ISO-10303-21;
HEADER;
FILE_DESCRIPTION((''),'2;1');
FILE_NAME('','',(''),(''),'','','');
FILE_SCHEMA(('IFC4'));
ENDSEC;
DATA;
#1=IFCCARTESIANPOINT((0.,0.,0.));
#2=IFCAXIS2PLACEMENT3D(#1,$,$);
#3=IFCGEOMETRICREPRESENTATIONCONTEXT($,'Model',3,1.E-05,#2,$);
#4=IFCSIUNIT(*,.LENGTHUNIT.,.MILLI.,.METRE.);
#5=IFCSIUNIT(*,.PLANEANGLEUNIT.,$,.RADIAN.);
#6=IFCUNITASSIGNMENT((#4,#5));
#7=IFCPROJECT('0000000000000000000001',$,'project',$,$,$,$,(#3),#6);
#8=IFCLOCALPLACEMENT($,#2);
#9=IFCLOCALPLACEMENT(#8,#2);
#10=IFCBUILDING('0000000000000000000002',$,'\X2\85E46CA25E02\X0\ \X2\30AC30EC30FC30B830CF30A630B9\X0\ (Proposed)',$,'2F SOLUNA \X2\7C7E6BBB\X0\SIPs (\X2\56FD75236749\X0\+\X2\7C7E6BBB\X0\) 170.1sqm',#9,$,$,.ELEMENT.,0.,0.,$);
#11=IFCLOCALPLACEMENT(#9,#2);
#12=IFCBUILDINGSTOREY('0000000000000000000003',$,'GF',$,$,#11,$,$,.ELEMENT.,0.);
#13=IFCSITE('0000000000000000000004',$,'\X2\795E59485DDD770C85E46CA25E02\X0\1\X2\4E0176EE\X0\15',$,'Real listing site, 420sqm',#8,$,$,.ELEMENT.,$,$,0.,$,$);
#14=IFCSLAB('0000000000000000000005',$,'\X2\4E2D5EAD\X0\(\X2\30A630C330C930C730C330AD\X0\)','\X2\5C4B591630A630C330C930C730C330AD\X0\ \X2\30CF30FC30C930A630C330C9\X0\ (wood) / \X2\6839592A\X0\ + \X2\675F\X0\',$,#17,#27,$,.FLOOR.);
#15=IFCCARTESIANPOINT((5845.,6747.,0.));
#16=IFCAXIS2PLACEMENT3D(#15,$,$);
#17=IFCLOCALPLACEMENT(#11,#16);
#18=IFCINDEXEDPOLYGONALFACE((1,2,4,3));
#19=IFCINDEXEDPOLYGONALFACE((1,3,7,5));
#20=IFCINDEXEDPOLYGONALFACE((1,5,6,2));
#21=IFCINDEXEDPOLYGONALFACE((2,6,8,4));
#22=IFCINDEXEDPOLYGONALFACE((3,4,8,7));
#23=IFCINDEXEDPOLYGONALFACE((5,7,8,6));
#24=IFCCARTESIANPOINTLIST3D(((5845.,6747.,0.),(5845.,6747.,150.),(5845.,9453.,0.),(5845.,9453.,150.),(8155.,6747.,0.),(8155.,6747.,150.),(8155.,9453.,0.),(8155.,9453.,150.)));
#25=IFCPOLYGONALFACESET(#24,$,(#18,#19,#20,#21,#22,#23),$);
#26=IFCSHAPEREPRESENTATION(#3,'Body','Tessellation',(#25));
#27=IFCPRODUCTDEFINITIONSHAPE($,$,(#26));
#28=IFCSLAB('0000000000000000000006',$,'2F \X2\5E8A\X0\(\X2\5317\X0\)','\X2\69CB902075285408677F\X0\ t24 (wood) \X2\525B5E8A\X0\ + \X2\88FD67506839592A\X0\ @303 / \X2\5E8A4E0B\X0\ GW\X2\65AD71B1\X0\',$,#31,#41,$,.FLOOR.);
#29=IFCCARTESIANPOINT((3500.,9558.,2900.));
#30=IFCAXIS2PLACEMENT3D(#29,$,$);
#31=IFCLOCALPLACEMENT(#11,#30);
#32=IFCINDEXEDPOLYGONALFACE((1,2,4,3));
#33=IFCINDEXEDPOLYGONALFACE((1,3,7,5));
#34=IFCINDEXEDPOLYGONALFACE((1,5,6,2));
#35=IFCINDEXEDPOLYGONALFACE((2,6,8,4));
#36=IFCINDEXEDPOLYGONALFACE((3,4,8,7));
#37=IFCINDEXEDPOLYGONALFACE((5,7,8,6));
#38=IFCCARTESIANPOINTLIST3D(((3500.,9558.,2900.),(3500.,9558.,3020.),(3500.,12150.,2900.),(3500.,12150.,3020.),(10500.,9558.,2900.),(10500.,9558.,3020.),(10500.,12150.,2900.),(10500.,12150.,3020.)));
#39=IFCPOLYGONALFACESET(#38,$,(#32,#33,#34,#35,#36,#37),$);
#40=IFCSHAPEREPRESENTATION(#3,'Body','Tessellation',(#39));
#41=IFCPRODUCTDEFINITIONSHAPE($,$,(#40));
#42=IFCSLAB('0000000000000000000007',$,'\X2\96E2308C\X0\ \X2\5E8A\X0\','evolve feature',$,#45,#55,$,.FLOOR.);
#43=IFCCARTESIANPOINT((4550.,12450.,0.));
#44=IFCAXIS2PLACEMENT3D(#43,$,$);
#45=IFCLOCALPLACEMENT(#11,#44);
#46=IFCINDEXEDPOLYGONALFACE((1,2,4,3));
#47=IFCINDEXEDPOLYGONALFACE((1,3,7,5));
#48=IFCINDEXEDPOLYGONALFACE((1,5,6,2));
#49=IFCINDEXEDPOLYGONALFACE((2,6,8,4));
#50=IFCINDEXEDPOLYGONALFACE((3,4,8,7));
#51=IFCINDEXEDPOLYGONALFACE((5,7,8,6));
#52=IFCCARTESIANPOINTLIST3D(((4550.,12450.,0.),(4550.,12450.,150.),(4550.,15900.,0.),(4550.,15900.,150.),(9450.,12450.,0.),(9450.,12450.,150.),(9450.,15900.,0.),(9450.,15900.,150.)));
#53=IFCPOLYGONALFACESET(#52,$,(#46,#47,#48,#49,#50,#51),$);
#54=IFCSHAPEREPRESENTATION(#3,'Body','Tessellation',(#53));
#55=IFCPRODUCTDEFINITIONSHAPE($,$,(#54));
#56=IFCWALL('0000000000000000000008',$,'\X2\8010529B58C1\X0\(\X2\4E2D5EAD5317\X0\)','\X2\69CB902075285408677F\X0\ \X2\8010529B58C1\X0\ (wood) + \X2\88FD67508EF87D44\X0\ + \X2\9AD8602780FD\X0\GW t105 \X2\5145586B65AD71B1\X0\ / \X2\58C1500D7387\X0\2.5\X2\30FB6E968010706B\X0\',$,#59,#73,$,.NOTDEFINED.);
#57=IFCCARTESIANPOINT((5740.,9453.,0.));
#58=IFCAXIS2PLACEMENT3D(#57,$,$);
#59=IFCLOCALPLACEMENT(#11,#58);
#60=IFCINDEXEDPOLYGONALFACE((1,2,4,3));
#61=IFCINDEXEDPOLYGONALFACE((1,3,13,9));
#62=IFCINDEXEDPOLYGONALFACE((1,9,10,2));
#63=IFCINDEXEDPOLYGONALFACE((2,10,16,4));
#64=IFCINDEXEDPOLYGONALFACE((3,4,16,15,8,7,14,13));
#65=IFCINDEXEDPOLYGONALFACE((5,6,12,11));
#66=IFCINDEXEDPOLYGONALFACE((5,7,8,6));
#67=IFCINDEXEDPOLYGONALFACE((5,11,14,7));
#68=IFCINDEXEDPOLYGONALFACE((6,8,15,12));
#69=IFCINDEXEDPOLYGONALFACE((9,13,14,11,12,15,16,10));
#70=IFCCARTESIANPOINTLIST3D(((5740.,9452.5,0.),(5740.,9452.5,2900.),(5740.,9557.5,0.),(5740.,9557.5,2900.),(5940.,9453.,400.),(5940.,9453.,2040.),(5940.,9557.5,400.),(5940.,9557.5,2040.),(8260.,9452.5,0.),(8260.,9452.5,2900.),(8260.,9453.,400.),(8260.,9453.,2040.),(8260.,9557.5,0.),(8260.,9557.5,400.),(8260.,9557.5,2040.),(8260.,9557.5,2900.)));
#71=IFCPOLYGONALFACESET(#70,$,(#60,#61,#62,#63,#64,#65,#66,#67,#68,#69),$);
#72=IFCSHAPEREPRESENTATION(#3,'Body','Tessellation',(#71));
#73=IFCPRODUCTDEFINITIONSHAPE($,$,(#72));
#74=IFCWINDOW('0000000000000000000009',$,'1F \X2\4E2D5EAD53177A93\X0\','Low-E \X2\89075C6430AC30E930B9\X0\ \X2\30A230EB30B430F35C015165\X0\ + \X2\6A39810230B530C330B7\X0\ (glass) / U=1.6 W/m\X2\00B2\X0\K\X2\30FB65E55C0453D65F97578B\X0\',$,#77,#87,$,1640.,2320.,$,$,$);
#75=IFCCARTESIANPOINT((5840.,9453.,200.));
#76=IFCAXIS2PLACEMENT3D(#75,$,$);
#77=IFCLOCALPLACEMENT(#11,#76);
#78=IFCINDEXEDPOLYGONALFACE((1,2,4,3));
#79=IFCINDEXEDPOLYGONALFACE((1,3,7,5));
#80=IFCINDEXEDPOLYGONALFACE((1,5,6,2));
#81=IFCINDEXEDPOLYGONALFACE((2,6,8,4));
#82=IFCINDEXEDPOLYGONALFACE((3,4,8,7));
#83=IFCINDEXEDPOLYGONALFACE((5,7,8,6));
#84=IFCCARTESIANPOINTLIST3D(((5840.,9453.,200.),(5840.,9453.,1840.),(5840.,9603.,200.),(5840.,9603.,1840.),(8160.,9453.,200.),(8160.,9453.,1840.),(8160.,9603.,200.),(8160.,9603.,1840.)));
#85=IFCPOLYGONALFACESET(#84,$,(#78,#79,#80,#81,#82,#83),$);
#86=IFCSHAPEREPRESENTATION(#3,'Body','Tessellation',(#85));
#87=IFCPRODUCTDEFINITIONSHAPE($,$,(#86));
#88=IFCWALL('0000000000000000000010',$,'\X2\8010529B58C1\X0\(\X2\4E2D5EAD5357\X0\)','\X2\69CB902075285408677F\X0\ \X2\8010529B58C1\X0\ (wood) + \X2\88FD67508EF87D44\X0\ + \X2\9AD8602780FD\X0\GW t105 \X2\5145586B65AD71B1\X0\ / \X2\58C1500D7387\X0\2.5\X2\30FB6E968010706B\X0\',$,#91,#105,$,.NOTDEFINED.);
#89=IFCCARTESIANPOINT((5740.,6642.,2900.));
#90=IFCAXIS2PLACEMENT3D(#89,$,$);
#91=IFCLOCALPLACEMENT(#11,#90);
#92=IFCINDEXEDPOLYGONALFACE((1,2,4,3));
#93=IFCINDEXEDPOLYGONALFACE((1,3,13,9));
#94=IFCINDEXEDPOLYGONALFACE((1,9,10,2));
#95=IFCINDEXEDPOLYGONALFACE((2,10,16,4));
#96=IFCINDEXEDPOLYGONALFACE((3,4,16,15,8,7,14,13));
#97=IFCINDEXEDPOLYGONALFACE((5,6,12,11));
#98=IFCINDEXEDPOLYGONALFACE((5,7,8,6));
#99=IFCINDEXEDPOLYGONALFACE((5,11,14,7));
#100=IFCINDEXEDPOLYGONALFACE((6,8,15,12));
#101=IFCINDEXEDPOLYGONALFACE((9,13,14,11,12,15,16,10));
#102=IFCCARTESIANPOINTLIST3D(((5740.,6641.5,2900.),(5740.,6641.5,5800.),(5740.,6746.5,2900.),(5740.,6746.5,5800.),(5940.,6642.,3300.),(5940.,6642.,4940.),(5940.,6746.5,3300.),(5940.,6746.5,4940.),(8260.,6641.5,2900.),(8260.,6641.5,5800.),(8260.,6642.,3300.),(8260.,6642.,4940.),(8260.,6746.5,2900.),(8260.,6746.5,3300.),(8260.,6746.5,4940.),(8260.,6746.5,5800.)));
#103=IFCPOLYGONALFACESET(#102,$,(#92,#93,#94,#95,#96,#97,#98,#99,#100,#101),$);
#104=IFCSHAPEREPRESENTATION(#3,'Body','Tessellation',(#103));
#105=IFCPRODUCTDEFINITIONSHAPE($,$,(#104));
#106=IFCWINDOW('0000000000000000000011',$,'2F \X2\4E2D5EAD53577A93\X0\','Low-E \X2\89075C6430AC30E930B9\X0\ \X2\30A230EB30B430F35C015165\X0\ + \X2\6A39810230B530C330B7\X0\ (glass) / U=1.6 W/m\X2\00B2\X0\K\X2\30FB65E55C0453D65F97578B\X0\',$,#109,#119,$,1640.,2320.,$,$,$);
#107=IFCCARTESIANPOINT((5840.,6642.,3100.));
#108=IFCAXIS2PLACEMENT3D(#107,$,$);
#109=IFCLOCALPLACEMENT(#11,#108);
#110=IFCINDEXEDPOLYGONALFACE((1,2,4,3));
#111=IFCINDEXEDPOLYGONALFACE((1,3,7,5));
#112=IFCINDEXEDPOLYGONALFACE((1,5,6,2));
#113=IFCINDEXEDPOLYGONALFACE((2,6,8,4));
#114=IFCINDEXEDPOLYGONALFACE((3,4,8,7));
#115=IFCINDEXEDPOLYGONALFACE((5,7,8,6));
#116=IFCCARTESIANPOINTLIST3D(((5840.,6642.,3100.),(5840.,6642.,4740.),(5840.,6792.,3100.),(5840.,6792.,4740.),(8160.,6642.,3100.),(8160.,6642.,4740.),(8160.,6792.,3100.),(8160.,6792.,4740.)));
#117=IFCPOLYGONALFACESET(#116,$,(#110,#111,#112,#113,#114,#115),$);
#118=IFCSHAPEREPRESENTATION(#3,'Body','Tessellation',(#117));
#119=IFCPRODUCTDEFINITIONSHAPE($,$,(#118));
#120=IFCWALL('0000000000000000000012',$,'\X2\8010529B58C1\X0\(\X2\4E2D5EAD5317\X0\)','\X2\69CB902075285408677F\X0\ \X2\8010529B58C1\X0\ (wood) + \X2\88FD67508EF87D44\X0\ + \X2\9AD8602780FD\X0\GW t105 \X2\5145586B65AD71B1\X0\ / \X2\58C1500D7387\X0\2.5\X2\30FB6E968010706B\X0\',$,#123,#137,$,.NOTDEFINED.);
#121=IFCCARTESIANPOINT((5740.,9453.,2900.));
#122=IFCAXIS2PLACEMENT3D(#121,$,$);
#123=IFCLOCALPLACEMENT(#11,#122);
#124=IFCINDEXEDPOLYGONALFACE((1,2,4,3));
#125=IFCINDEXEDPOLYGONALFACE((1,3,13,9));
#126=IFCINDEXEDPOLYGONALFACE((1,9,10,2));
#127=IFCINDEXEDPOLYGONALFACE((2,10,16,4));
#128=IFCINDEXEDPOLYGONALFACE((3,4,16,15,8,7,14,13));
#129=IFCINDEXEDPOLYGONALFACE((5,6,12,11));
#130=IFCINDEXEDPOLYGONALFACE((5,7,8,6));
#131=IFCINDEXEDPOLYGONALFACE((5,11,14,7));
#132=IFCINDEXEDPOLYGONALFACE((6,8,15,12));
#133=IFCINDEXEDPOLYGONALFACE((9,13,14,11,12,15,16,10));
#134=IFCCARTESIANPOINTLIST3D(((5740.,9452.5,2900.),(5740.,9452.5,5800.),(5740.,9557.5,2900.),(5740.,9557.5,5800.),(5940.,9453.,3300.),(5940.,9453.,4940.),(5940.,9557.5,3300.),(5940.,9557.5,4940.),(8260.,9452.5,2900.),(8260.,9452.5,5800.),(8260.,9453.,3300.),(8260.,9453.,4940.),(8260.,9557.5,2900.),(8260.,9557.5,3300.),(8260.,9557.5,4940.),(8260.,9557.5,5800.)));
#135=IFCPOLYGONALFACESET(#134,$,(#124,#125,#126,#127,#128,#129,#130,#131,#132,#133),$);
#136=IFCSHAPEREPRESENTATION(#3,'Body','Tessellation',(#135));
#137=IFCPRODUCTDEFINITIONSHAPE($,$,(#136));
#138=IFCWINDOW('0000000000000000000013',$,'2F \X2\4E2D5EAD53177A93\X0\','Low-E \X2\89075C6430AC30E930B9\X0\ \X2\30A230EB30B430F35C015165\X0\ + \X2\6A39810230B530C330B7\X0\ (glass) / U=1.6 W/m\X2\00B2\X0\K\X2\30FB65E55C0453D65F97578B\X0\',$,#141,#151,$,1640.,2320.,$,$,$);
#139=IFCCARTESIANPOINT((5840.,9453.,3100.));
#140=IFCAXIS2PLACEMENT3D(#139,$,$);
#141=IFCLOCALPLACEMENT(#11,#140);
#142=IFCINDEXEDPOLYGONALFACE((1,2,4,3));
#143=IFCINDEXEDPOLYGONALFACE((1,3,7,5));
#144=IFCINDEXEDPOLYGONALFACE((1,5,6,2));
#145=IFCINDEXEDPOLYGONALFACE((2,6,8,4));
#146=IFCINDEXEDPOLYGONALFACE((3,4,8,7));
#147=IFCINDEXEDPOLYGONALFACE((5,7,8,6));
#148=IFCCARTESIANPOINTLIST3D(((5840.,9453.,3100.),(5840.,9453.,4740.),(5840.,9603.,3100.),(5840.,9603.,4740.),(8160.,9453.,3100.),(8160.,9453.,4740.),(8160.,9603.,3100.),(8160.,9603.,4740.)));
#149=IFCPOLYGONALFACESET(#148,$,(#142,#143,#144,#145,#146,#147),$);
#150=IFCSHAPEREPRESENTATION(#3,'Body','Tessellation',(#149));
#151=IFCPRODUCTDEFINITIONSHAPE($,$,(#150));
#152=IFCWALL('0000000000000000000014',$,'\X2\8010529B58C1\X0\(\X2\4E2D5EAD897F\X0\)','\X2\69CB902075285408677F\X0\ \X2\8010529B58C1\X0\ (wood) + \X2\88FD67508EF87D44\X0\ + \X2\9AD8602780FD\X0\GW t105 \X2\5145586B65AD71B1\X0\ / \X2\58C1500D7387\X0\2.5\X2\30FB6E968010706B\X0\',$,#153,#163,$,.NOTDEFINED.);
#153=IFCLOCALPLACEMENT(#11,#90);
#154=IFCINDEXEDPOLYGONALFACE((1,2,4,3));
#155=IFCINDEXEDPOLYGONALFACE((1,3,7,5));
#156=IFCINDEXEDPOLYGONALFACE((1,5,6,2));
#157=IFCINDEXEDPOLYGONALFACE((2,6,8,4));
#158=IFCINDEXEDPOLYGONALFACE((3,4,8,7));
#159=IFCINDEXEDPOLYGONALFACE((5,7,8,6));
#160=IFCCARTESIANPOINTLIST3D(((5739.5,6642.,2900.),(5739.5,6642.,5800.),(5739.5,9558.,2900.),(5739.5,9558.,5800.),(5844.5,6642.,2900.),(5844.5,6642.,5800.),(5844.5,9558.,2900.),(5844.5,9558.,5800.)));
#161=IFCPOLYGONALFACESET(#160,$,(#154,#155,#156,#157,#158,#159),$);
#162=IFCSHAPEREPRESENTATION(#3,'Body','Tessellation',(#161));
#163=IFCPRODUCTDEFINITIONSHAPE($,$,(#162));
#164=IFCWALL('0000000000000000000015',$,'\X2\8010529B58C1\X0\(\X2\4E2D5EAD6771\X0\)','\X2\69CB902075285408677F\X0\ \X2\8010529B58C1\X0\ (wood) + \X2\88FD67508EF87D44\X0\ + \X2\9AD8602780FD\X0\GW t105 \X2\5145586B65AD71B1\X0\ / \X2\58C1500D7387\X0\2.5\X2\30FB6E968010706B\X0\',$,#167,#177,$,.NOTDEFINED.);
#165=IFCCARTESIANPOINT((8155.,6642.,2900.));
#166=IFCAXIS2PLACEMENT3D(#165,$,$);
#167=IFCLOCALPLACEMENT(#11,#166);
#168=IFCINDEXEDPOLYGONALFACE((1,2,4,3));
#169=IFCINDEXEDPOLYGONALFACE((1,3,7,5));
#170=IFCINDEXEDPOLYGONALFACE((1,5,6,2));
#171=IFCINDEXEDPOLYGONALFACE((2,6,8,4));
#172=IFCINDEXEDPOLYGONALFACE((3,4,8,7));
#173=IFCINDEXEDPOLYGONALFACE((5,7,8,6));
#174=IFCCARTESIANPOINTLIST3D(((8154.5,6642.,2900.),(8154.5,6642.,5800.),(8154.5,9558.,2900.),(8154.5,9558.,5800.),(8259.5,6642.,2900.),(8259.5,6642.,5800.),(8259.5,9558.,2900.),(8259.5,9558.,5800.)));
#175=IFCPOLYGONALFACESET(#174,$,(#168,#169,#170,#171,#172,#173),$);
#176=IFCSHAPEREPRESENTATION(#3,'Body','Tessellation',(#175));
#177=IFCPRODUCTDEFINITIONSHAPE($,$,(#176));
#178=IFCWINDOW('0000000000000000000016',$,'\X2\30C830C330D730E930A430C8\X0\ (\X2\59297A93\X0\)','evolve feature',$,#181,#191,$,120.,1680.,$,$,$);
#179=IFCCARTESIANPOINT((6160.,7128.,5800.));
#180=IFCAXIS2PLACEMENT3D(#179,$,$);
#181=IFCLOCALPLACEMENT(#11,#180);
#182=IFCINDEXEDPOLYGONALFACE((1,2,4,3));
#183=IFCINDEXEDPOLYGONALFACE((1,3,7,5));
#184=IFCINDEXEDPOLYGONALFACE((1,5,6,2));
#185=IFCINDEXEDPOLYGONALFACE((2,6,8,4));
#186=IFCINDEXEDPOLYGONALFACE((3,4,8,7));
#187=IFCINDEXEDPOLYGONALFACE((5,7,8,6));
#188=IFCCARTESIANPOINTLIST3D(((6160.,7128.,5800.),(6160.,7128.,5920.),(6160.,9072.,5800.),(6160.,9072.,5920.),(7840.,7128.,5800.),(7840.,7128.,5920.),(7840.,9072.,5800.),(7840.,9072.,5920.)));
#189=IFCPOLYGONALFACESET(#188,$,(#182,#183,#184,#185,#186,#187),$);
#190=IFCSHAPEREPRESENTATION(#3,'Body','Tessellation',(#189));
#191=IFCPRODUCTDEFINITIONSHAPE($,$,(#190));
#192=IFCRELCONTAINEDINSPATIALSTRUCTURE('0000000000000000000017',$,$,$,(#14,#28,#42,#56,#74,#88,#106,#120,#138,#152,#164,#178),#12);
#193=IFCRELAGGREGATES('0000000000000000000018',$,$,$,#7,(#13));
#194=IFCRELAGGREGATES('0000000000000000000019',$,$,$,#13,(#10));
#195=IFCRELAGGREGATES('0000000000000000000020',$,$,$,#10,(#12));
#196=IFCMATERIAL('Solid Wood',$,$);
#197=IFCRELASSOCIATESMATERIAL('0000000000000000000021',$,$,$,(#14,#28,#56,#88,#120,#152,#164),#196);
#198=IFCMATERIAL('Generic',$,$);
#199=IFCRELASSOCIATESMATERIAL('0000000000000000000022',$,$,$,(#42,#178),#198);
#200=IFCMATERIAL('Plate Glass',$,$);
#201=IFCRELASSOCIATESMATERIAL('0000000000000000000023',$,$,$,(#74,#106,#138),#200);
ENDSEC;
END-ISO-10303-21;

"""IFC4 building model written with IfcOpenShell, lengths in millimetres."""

from ifc_helpers import new_model, si_unit, frame, frame_2d, origin, place, context, project, spatial, rectangle, extrude, material, element, fill, save


model = new_model("IFC4")

# Units and contexts
model_context = context("Model", 3, precision=1e-05, world=origin())
ifc_project = project(units=[si_unit("LENGTHUNIT", "METRE", prefix="MILLI"), si_unit("PLANEANGLEUNIT", "RADIAN")], contexts=[model_context])

# Site, building, storey
site_placement = place(None, origin())
site = spatial("IfcSite", under=ifc_project, at=site_placement, Name="神奈川県藤沢市1丁目15", ObjectType="Real listing site, 420sqm", CompositionType="ELEMENT", RefElevation=0.0)
building_placement = place(site_placement, origin())
building = spatial("IfcBuilding", under=site, at=building_placement, Name="藤沢市 ガレージハウス (Proposed)", ObjectType="2F SOLUNA 籾殻SIPs (国産杉+籾殻) 170.1sqm", CompositionType="ELEMENT", ElevationOfRefHeight=0.0, ElevationOfTerrain=0.0)
storey_placement = place(building_placement, origin())
storey = spatial("IfcBuildingStorey", under=building, at=storey_placement, Name="GF", CompositionType="ELEMENT", Elevation=0.0)

# Slabs
ifc_material_1 = material(Name="Solid Wood")
slab_1_placement = place(storey_placement, frame((5845.0, 6747.0, 0.0)))
element("IfcSlab", 1, at=slab_1_placement, inside=storey, material=ifc_material_1, Name="中庭(ウッドデッキ)", Description="屋外ウッドデッキ ハードウッド (wood) / 根太 + 束", PredefinedType="FLOOR", context=model_context, shape_type="SweptSolid", body=[
    extrude(rectangle(XDim=2310.0, YDim=2706.0, at=frame_2d((1155.0, 1353.0))), frame((5845.0, 6747.0, 0.0)), (0.0, 0.0, 1.0), 150.0),
])
slab_2_placement = place(storey_placement, frame((3500.0, 9558.0, 2900.0)))
element("IfcSlab", 2, at=slab_2_placement, inside=storey, material=ifc_material_1, Name="2F 床(北)", Description="構造用合板 t24 (wood) 剛床 + 製材根太 @303 / 床下 GW断熱", PredefinedType="FLOOR", context=model_context, shape_type="SweptSolid", body=[
    extrude(rectangle(XDim=7000.0, YDim=2592.0, at=frame_2d((3500.0, 1296.0))), frame((3500.0, 9558.0, 2900.0)), (0.0, 0.0, 1.0), 120.0),
])
ifc_material_2 = material(Name="Generic")
slab_3_placement = place(storey_placement, frame((4550.0, 12450.0, 0.0)))
element("IfcSlab", 3, at=slab_3_placement, inside=storey, material=ifc_material_2, Name="離れ 床", Description="evolve feature", PredefinedType="FLOOR", context=model_context, shape_type="SweptSolid", body=[
    extrude(rectangle(XDim=4900.0, YDim=3450.0, at=frame_2d((2450.0, 1725.0))), frame((4550.0, 12450.0, 0.0)), (0.0, 0.0, 1.0), 150.0),
])

# Wall, opening, window
wall_1_placement = place(storey_placement, frame((5740.0, 9453.0, 0.0)))
wall_1 = element("IfcWall", 4, at=wall_1_placement, inside=storey, material=ifc_material_1, Name="耐力壁(中庭北)", Description="構造用合板 耐力壁 (wood) + 製材軸組 + 高性能GW t105 充填断熱 / 壁倍率2.5・準耐火", PredefinedType="NOTDEFINED", context=model_context, shape_type="SweptSolid", body=[
    extrude(rectangle(XDim=2520.0, YDim=105.0, at=frame_2d((1260.0, 52.0))), frame((5740.0, 9453.0, 0.0)), (0.0, 0.0, 1.0), 2900.0),
])
opening_1_placement = place(storey_placement, frame((5840.0, 9453.0, 200.0)))
opening_1 = element("IfcOpeningElement", 5, at=opening_1_placement, cuts=wall_1, PredefinedType="NOTDEFINED", context=model_context, shape_type="SweptSolid", body=[
    extrude(rectangle(XDim=2320.0, YDim=150.0, at=frame_2d((1160.0, 75.0))), frame((5840.0, 9453.0, 200.0)), (0.0, 0.0, 1.0), 1640.0),
])
ifc_material_3 = material(Name="Plate Glass")
window_1_placement = place(storey_placement, frame((5840.0, 9453.0, 200.0)))
window_1 = element("IfcWindow", 6, at=window_1_placement, inside=storey, material=ifc_material_3, Name="1F 中庭北窓", Description="Low-E 複層ガラス アルゴン封入 + 樹脂サッシ (glass) / U=1.6 W/m²K・日射取得型", OverallHeight=1640.0, OverallWidth=2320.0, context=model_context, shape_type="SweptSolid", body=[
    extrude(rectangle(XDim=2320.0, YDim=150.0, at=frame_2d((1160.0, 75.0))), frame((5840.0, 9453.0, 200.0)), (0.0, 0.0, 1.0), 1640.0),
])
fill(opening_1, window_1)

# Walls, openings, windows
wall_2_placement = place(storey_placement, frame((5740.0, 6642.0, 2900.0)))
wall_2 = element("IfcWall", 7, at=wall_2_placement, inside=storey, material=ifc_material_1, Name="耐力壁(中庭南)", Description="構造用合板 耐力壁 (wood) + 製材軸組 + 高性能GW t105 充填断熱 / 壁倍率2.5・準耐火", PredefinedType="NOTDEFINED", context=model_context, shape_type="SweptSolid", body=[
    extrude(rectangle(XDim=2520.0, YDim=105.0, at=frame_2d((1260.0, 52.0))), frame((5740.0, 6642.0, 2900.0)), (0.0, 0.0, 1.0), 2900.0),
])
opening_2_placement = place(storey_placement, frame((5840.0, 6642.0, 3100.0)))
opening_2 = element("IfcOpeningElement", 8, at=opening_2_placement, cuts=wall_2, PredefinedType="NOTDEFINED", context=model_context, shape_type="SweptSolid", body=[
    extrude(rectangle(XDim=2320.0, YDim=150.0, at=frame_2d((1160.0, 75.0))), frame((5840.0, 6642.0, 3100.0)), (0.0, 0.0, 1.0), 1640.0),
])
window_2_placement = place(storey_placement, frame((5840.0, 6642.0, 3100.0)))
window_2 = element("IfcWindow", 9, at=window_2_placement, inside=storey, material=ifc_material_3, Name="2F 中庭南窓", Description="Low-E 複層ガラス アルゴン封入 + 樹脂サッシ (glass) / U=1.6 W/m²K・日射取得型", OverallHeight=1640.0, OverallWidth=2320.0, context=model_context, shape_type="SweptSolid", body=[
    extrude(rectangle(XDim=2320.0, YDim=150.0, at=frame_2d((1160.0, 75.0))), frame((5840.0, 6642.0, 3100.0)), (0.0, 0.0, 1.0), 1640.0),
])
fill(opening_2, window_2)
wall_3_placement = place(storey_placement, frame((5740.0, 9453.0, 2900.0)))
wall_3 = element("IfcWall", 10, at=wall_3_placement, inside=storey, material=ifc_material_1, Name="耐力壁(中庭北)", Description="構造用合板 耐力壁 (wood) + 製材軸組 + 高性能GW t105 充填断熱 / 壁倍率2.5・準耐火", PredefinedType="NOTDEFINED", context=model_context, shape_type="SweptSolid", body=[
    extrude(rectangle(XDim=2520.0, YDim=105.0, at=frame_2d((1260.0, 52.0))), frame((5740.0, 9453.0, 2900.0)), (0.0, 0.0, 1.0), 2900.0),
])
opening_3_placement = place(storey_placement, frame((5840.0, 9453.0, 3100.0)))
opening_3 = element("IfcOpeningElement", 11, at=opening_3_placement, cuts=wall_3, PredefinedType="NOTDEFINED", context=model_context, shape_type="SweptSolid", body=[
    extrude(rectangle(XDim=2320.0, YDim=150.0, at=frame_2d((1160.0, 75.0))), frame((5840.0, 9453.0, 3100.0)), (0.0, 0.0, 1.0), 1640.0),
])
window_3_placement = place(storey_placement, frame((5840.0, 9453.0, 3100.0)))
window_3 = element("IfcWindow", 12, at=window_3_placement, inside=storey, material=ifc_material_3, Name="2F 中庭北窓", Description="Low-E 複層ガラス アルゴン封入 + 樹脂サッシ (glass) / U=1.6 W/m²K・日射取得型", OverallHeight=1640.0, OverallWidth=2320.0, context=model_context, shape_type="SweptSolid", body=[
    extrude(rectangle(XDim=2320.0, YDim=150.0, at=frame_2d((1160.0, 75.0))), frame((5840.0, 9453.0, 3100.0)), (0.0, 0.0, 1.0), 1640.0),
])
fill(opening_3, window_3)

# Walls
wall_4_placement = place(storey_placement, frame((5740.0, 6642.0, 2900.0)))
element("IfcWall", 13, at=wall_4_placement, inside=storey, material=ifc_material_1, Name="耐力壁(中庭西)", Description="構造用合板 耐力壁 (wood) + 製材軸組 + 高性能GW t105 充填断熱 / 壁倍率2.5・準耐火", PredefinedType="NOTDEFINED", context=model_context, shape_type="SweptSolid", body=[
    extrude(rectangle(XDim=105.0, YDim=2916.0, at=frame_2d((52.0, 1458.0))), frame((5740.0, 6642.0, 2900.0)), (0.0, 0.0, 1.0), 2900.0),
])
wall_5_placement = place(storey_placement, frame((8155.0, 6642.0, 2900.0)))
element("IfcWall", 14, at=wall_5_placement, inside=storey, material=ifc_material_1, Name="耐力壁(中庭東)", Description="構造用合板 耐力壁 (wood) + 製材軸組 + 高性能GW t105 充填断熱 / 壁倍率2.5・準耐火", PredefinedType="NOTDEFINED", context=model_context, shape_type="SweptSolid", body=[
    extrude(rectangle(XDim=105.0, YDim=2916.0, at=frame_2d((52.0, 1458.0))), frame((8155.0, 6642.0, 2900.0)), (0.0, 0.0, 1.0), 2900.0),
])

# Window
window_4_placement = place(storey_placement, frame((6160.0, 7128.0, 5800.0)))
element("IfcWindow", 15, at=window_4_placement, inside=storey, material=ifc_material_2, Name="トップライト (天窓)", Description="evolve feature", OverallHeight=120.0, OverallWidth=1680.0, context=model_context, shape_type="SweptSolid", body=[
    extrude(rectangle(XDim=1680.0, YDim=1944.0, at=frame_2d((840.0, 972.0))), frame((6160.0, 7128.0, 5800.0)), (0.0, 0.0, 1.0), 120.0),
])

save(model, "model.ifc")
